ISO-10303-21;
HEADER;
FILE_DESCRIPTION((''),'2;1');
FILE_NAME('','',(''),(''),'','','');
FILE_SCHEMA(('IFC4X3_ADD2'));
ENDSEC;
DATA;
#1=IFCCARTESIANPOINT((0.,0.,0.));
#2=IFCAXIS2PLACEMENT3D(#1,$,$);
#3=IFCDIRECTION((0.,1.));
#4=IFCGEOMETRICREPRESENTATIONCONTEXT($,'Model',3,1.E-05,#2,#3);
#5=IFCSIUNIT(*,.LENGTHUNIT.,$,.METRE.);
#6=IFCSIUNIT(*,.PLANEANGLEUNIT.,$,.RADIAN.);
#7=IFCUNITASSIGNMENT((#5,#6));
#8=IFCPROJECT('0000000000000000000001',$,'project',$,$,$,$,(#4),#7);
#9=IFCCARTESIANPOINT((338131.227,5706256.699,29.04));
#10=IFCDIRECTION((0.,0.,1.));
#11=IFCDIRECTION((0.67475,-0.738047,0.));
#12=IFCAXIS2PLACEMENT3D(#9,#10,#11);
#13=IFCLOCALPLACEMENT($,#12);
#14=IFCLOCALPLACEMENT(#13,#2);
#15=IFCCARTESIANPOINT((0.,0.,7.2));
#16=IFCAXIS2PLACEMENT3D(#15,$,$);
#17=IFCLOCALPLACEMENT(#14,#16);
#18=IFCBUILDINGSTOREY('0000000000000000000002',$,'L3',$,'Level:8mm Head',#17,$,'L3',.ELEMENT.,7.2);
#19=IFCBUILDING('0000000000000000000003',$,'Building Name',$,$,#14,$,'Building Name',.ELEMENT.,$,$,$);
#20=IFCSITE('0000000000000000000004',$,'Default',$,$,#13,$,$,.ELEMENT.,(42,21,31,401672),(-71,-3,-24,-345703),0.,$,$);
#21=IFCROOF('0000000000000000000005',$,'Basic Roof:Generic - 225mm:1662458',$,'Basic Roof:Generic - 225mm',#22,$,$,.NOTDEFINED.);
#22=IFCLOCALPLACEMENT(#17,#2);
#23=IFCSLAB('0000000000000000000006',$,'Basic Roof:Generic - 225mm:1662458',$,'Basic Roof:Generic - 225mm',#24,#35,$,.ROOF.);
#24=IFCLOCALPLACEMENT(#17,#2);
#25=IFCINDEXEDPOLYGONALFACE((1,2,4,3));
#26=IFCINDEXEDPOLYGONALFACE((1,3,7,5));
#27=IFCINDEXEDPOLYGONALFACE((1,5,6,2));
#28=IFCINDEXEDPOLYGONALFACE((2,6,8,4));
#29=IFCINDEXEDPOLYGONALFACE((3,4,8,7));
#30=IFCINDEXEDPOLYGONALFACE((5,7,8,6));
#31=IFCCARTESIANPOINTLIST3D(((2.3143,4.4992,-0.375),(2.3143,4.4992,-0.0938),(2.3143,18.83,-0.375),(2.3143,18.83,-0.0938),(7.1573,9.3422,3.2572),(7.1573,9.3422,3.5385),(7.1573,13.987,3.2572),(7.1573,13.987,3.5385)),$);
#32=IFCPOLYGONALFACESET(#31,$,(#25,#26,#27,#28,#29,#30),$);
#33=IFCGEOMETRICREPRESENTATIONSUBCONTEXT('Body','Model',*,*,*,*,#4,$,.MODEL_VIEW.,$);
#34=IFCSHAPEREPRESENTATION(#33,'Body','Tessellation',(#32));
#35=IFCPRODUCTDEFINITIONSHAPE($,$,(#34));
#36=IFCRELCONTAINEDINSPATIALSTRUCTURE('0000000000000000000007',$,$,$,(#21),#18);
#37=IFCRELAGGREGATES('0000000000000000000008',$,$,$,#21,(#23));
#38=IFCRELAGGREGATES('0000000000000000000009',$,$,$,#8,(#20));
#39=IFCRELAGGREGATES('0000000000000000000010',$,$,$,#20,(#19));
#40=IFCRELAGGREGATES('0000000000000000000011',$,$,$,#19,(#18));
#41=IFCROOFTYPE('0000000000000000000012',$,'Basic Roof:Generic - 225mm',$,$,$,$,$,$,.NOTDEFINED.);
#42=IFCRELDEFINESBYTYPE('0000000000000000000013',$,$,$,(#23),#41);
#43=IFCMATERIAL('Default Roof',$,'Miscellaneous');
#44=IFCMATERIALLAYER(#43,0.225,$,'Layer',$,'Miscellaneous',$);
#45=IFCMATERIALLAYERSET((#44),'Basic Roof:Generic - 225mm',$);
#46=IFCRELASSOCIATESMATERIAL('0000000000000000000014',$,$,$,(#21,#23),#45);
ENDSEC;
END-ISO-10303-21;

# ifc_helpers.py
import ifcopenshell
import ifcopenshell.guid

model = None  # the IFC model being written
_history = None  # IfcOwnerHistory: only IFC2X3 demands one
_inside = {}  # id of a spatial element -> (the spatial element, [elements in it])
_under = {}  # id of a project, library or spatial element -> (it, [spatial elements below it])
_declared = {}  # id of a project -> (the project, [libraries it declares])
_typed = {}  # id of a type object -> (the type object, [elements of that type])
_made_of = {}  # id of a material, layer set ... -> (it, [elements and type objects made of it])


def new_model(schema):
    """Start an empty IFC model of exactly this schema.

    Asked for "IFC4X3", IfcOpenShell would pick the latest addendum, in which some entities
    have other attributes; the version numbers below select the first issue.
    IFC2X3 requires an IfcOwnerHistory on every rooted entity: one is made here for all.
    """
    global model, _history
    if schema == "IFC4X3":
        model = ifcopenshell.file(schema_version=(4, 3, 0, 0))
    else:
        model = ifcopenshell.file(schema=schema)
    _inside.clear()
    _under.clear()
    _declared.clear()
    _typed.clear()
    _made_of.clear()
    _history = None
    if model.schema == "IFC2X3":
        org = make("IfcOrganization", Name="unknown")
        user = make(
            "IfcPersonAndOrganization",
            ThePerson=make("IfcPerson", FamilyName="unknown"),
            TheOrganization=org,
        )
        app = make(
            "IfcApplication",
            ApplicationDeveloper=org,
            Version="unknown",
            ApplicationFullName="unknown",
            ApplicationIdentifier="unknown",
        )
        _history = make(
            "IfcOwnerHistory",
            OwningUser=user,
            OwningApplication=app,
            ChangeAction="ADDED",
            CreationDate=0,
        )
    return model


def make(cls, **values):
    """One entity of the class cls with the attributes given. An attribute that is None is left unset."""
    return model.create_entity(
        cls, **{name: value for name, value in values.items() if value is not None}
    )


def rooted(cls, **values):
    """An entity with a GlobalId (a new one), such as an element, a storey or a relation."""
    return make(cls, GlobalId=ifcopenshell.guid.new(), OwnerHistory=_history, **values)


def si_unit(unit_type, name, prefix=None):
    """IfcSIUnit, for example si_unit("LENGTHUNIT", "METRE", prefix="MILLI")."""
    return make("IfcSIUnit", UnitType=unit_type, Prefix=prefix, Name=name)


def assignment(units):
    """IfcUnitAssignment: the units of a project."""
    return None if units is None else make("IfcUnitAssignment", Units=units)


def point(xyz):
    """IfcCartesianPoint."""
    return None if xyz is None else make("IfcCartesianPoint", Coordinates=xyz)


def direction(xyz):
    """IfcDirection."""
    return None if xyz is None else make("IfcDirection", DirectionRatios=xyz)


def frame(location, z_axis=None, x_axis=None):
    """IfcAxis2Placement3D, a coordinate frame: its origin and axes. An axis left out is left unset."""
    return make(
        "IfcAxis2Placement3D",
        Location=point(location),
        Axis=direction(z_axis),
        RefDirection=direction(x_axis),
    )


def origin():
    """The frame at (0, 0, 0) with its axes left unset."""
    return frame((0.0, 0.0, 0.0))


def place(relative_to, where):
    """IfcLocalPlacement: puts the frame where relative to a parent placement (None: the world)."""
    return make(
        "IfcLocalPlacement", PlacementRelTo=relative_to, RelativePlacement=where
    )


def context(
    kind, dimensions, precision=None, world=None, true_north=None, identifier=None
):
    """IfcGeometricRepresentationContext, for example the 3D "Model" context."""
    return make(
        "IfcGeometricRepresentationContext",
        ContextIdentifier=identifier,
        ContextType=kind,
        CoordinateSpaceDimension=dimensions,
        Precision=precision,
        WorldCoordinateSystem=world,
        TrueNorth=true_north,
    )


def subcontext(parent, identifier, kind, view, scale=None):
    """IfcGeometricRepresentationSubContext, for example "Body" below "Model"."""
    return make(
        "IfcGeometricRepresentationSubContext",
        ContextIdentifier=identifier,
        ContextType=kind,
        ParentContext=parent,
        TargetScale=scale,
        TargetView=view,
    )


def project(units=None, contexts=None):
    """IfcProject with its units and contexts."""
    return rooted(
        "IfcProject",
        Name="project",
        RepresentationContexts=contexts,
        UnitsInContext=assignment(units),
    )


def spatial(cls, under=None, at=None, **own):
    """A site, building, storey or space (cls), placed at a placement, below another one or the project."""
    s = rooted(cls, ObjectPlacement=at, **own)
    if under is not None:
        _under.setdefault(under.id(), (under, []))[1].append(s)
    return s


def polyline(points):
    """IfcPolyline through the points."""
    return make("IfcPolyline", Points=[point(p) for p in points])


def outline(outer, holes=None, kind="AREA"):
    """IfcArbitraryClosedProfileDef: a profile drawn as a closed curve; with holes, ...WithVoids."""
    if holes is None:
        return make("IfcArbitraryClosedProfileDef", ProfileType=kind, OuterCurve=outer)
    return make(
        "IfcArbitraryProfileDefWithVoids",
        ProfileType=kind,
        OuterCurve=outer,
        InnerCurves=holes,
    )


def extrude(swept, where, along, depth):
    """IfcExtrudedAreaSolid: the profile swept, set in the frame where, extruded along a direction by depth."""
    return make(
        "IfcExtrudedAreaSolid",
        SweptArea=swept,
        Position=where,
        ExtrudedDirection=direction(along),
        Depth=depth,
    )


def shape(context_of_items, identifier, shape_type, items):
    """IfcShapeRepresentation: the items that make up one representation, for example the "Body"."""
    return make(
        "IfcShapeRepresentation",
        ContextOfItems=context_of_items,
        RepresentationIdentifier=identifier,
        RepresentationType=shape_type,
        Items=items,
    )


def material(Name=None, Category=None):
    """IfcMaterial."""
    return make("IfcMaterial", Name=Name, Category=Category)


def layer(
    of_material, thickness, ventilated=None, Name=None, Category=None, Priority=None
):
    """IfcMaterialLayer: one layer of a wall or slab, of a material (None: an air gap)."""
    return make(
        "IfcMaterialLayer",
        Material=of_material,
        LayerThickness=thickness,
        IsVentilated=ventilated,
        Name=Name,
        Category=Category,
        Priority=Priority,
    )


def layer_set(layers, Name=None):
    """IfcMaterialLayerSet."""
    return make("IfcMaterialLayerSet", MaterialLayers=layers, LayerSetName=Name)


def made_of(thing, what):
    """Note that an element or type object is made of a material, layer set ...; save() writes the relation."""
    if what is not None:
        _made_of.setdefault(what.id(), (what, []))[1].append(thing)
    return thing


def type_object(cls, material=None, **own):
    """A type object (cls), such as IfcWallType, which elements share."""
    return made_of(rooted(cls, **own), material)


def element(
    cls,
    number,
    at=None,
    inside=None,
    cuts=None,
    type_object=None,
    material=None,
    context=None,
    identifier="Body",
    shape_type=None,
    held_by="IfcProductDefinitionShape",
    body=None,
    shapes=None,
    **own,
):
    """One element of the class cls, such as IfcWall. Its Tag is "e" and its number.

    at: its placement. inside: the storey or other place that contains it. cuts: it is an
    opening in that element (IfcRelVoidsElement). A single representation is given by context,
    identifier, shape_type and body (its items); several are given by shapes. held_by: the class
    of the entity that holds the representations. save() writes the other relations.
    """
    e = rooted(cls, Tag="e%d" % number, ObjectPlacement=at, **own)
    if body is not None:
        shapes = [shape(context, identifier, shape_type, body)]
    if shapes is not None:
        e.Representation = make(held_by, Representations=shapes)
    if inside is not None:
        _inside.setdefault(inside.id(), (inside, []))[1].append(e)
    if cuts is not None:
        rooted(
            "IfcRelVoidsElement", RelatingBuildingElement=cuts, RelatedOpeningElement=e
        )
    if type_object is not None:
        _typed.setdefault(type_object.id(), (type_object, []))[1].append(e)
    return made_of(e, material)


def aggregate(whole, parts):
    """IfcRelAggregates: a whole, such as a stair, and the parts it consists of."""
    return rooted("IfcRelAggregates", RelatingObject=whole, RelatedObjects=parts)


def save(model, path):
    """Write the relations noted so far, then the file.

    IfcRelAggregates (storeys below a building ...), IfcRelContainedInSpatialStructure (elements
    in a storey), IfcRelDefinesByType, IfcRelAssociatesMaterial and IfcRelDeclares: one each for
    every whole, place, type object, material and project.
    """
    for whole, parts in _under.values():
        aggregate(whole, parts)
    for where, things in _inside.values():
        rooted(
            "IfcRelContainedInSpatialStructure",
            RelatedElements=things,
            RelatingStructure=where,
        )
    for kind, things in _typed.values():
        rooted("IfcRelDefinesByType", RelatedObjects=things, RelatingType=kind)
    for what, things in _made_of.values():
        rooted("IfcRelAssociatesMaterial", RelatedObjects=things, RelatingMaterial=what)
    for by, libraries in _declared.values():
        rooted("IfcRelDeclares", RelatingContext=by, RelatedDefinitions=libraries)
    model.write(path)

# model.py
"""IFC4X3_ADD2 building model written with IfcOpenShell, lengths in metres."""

from ifc_helpers import new_model, si_unit, direction, frame, origin, place, context, subcontext, project, spatial, polyline, outline, extrude, material, layer, layer_set, type_object, element, aggregate, save


model = new_model("IFC4X3_ADD2")

# Units and contexts
model_context = context("Model", 3, precision=1e-05, world=origin(), true_north=direction((0.0, 1.0)))
body_context = subcontext(model_context, "Body", "Model", "MODEL_VIEW")
ifc_project = project(units=[si_unit("LENGTHUNIT", "METRE"), si_unit("PLANEANGLEUNIT", "RADIAN")], contexts=[model_context])

# Site, building, storey
site_placement = place(None, frame((338131.227, 5706256.699, 29.04), z_axis=(0.0, 0.0, 1.0), x_axis=(0.67475, -0.738047, 0.0)))
site = spatial("IfcSite", under=ifc_project, at=site_placement, Name="Default", CompositionType="ELEMENT", RefLatitude=(42, 21, 31, 401672), RefLongitude=(-71, -3, -24, -345703), RefElevation=0.0)
building_placement = place(site_placement, origin())
building = spatial("IfcBuilding", under=site, at=building_placement, Name="Building Name", LongName="Building Name", CompositionType="ELEMENT")
storey_placement = place(building_placement, frame((0.0, 0.0, 7.2)))
storey = spatial("IfcBuildingStorey", under=building, at=storey_placement, Name="L3", ObjectType="Level:8mm Head", LongName="L3", CompositionType="ELEMENT", Elevation=7.2)

# Roof, slab
ifc_material = material(Name="Default Roof", Category="Miscellaneous")
ifc_layer = layer(ifc_material, 0.225, Name="Layer", Category="Miscellaneous")
ifc_layer_set = layer_set([ifc_layer], Name="Basic Roof:Generic - 225mm")
roof_placement = place(storey_placement, frame((2.3143, 4.4991, -0.375)))
roof = element("IfcRoof", 1, at=roof_placement, inside=storey, material=ifc_layer_set, Name="Basic Roof:Generic - 225mm:1662458", ObjectType="Basic Roof:Generic - 225mm", PredefinedType="NOTDEFINED")
roof_type = type_object("IfcRoofType", Name="Basic Roof:Generic - 225mm", PredefinedType="NOTDEFINED")
slab_1_placement = place(roof_placement, origin())
slab_1 = element("IfcSlab", 2, at=slab_1_placement, type_object=roof_type, material=ifc_layer_set, Name="Basic Roof:Generic - 225mm:1662458", ObjectType="Basic Roof:Generic - 225mm", PredefinedType="ROOF", context=body_context, shape_type="SweptSolid", body=[
    extrude(outline(polyline([(-3.0269, -7.1654), (3.0268, -2.3224), (3.0269, 2.3224), (-3.0268, 7.1654), (-3.0269, -7.1654)])), frame((2.4215, 7.1655, 1.8161), z_axis=(-0.6, 0.000004, 0.8), x_axis=(0.8, 0.000003, 0.6)), (0.6, -0.000005, 0.8), 0.2812),
])
aggregate(roof, [slab_1])

save(model, "model.ifc")
